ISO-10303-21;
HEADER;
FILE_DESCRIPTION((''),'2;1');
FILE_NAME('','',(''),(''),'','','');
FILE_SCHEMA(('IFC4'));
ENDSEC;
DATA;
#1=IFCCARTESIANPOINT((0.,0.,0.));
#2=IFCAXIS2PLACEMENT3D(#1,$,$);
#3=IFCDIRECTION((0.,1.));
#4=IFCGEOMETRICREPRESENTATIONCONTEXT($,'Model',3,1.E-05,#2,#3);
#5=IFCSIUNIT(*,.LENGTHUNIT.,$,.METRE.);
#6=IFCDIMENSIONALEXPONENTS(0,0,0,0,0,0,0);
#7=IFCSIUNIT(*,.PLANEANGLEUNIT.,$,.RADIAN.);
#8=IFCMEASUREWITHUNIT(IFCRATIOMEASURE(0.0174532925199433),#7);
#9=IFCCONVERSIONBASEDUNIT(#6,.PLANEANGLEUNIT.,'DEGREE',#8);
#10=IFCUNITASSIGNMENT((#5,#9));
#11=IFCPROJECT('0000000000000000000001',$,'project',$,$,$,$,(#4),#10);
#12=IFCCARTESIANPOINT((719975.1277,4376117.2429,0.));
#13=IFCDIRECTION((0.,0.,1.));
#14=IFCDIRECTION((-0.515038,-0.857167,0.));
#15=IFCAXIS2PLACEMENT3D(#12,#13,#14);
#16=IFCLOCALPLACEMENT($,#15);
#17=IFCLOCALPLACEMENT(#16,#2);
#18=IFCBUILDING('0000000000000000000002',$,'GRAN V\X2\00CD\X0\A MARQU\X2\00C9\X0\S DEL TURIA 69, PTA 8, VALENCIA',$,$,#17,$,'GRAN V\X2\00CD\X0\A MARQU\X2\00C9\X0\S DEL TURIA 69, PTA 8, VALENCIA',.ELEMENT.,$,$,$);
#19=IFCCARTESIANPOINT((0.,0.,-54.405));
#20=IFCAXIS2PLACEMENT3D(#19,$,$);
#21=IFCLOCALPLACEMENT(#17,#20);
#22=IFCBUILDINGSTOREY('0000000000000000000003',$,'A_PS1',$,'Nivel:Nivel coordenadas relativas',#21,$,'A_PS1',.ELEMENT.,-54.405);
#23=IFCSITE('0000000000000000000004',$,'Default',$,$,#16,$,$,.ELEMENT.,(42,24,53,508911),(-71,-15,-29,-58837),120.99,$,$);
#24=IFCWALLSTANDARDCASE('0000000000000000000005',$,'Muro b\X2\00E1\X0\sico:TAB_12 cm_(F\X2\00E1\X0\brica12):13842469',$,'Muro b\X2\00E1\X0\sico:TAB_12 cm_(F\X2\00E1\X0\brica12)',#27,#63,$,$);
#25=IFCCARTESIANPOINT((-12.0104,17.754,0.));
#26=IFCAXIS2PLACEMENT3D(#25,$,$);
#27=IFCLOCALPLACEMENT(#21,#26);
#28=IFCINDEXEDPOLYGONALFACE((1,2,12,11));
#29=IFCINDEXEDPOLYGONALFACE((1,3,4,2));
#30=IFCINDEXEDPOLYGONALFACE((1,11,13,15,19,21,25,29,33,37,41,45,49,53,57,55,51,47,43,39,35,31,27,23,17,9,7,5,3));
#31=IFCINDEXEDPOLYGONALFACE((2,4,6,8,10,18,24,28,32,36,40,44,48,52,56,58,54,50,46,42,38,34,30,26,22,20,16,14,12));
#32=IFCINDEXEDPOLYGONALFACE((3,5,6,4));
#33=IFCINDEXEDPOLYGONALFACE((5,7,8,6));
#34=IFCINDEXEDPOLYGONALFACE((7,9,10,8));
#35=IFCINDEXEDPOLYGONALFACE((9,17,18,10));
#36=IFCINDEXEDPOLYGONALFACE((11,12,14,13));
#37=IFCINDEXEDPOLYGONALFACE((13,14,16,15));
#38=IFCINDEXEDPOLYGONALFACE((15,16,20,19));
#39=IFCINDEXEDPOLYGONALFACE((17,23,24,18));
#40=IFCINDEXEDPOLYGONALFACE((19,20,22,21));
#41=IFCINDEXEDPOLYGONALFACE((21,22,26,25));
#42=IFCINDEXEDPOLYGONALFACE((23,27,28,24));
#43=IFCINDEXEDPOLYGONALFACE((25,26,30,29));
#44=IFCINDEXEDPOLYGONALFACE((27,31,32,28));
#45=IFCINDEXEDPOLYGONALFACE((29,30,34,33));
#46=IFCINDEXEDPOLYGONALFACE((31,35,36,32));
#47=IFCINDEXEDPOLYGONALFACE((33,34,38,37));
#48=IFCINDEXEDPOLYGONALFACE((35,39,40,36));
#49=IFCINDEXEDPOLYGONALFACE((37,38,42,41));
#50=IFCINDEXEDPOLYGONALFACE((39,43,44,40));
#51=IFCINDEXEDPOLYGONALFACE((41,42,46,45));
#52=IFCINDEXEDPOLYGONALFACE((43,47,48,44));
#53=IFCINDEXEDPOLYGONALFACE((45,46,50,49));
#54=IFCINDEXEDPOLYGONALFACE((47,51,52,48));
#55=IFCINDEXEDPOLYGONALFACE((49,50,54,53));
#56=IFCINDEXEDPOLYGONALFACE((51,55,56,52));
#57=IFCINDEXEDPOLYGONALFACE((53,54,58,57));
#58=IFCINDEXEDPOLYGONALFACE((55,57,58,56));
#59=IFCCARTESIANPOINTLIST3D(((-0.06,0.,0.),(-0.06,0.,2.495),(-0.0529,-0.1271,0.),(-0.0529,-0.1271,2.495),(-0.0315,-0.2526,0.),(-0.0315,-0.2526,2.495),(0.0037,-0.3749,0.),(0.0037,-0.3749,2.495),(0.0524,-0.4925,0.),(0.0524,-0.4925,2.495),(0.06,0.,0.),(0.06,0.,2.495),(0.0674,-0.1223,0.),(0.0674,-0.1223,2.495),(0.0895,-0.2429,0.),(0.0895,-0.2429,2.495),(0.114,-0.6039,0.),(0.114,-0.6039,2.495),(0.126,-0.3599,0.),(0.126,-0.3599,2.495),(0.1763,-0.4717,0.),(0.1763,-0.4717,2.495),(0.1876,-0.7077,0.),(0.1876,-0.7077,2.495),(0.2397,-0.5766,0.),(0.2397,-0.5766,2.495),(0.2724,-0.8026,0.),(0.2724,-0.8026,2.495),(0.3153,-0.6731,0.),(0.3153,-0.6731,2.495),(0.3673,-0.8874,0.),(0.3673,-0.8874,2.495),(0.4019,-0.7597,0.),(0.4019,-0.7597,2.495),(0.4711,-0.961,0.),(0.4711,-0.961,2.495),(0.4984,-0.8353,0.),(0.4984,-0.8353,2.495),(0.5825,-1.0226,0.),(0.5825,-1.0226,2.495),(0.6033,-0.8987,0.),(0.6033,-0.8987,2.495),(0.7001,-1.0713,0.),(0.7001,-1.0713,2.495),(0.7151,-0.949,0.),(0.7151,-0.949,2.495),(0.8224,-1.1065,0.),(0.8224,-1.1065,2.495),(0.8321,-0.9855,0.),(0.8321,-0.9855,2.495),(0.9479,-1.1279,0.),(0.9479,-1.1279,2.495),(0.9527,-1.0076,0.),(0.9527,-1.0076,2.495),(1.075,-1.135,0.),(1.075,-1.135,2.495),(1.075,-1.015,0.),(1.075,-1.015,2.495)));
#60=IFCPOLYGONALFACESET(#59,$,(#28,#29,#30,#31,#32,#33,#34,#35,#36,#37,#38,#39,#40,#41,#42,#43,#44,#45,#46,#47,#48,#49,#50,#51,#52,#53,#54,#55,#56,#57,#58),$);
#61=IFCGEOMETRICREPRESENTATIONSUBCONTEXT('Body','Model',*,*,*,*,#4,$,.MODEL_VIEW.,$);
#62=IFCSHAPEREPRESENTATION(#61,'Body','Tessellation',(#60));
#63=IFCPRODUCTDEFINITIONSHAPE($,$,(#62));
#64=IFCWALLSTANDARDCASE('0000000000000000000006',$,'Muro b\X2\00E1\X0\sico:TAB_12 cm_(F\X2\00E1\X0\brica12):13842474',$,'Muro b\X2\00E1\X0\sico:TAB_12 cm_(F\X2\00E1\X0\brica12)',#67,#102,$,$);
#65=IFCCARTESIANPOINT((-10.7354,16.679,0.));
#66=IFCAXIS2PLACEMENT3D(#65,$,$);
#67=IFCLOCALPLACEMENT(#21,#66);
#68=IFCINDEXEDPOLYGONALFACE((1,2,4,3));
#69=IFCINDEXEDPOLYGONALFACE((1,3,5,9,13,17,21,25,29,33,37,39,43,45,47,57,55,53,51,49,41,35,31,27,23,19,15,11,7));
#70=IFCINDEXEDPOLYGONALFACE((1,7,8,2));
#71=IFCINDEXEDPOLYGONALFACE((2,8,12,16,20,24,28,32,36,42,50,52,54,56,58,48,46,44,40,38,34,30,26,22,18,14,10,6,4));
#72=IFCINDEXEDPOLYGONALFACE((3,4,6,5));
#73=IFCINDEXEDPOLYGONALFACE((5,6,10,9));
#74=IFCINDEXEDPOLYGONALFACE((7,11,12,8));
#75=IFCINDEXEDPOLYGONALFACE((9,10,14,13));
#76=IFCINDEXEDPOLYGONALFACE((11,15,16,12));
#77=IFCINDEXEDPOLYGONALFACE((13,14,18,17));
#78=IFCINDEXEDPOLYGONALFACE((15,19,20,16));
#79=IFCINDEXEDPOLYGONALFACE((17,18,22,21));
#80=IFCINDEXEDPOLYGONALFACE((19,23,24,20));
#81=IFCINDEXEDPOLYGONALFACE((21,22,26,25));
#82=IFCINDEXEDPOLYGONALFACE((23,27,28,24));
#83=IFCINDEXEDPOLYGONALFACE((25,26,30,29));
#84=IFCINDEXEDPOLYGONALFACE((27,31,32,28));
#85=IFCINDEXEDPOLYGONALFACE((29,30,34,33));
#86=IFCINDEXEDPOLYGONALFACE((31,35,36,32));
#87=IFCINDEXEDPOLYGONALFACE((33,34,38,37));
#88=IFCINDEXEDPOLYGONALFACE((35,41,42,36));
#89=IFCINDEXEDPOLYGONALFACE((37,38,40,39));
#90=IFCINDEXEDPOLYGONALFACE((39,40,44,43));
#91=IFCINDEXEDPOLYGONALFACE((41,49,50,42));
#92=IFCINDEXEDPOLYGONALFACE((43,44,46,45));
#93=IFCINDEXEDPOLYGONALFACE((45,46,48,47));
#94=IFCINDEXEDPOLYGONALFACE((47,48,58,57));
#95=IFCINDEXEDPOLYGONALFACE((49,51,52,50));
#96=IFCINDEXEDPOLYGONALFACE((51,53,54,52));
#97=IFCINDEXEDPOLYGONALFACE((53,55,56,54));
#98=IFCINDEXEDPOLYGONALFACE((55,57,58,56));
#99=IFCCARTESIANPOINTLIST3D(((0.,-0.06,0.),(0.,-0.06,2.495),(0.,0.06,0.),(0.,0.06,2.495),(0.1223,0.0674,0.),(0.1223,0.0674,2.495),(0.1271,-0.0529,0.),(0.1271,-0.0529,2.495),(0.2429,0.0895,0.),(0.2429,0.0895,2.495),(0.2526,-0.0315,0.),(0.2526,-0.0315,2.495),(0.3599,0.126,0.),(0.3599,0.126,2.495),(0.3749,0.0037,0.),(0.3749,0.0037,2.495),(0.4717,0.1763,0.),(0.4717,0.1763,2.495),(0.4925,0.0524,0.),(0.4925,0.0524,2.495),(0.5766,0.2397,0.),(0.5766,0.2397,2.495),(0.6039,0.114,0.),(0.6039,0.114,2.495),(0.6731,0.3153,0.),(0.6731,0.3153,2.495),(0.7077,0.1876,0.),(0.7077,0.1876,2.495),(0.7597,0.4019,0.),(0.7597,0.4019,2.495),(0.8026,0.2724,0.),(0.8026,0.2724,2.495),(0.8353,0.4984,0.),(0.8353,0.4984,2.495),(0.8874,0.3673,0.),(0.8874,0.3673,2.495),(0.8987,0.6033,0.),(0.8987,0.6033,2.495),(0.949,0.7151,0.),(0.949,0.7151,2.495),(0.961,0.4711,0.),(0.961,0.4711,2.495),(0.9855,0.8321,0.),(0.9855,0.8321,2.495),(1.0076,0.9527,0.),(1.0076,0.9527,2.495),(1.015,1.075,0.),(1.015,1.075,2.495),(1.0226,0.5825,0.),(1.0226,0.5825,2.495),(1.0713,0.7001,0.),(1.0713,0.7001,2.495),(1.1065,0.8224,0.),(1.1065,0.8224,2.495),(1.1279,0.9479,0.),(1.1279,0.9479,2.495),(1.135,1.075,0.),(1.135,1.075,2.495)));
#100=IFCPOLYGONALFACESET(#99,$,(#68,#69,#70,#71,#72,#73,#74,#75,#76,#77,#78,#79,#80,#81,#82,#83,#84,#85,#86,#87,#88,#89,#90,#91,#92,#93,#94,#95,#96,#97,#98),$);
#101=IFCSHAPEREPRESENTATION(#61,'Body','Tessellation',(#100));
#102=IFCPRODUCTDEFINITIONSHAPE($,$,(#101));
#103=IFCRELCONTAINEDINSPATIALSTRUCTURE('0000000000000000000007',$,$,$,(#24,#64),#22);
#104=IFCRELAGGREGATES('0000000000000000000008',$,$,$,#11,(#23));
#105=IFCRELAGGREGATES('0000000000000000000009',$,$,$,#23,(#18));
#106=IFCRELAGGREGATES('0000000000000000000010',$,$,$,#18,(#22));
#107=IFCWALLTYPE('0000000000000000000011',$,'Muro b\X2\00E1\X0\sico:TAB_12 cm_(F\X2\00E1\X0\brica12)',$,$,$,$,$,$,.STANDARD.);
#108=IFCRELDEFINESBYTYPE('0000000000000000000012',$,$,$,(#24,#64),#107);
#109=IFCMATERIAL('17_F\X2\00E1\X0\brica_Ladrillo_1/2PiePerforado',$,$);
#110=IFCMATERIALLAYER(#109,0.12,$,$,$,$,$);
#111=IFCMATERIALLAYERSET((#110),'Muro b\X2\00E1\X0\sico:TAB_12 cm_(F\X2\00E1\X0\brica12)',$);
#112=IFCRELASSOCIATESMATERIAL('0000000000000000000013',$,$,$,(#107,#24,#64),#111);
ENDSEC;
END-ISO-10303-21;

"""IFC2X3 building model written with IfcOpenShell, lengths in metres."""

from ifc_helpers import new_model, entity, si_unit, converted_unit, direction, frame, frame_2d, origin, place, context, subcontext, project, spatial, polyline, circle_curve, parameter, trimmed, segment, composite_curve, outline, extrude, material, layer, layer_set, layer_usage, type_object, element, save


model = new_model("IFC2X3")

# Units and contexts
model_context = context("Model", 3, precision=1e-05, world=origin(), true_north=direction((0.0, 1.0)))
body_context = subcontext(model_context, "Body", "Model", "MODEL_VIEW")
ifc_project = project(units=[si_unit("LENGTHUNIT", "METRE"), converted_unit("PLANEANGLEUNIT", "DEGREE", entity("IfcRatioMeasure", 0.0174532925199433), si_unit("PLANEANGLEUNIT", "RADIAN"), dimensions=[0, 0, 0, 0, 0, 0, 0])], contexts=[model_context])

# Site, building, storey
site_placement = place(None, frame((719975.1277, 4376117.2429, 0.0), z_axis=(0.0, 0.0, 1.0), x_axis=(-0.515038, -0.857167, 0.0)))
site = spatial("IfcSite", under=ifc_project, at=site_placement, Name="Default", CompositionType="ELEMENT", RefLatitude=(42, 24, 53, 508911), RefLongitude=(-71, -15, -29, -58837), RefElevation=120.99)
building_placement = place(site_placement, origin())
building = spatial("IfcBuilding", under=site, at=building_placement, Name="GRAN VÍA MARQUÉS DEL TURIA 69, PTA 8, VALENCIA", LongName="GRAN VÍA MARQUÉS DEL TURIA 69, PTA 8, VALENCIA", CompositionType="ELEMENT")
storey_placement = place(building_placement, frame((0.0, 0.0, -54.405)))
storey = spatial("IfcBuildingStorey", under=building, at=storey_placement, Name="A_PS1", ObjectType="Nivel:Nivel coordenadas relativas", LongName="A_PS1", CompositionType="ELEMENT", Elevation=-54.405)

# Shared definitions
ifc_material_1 = material(Name="17_Fábrica_Ladrillo_1/2PiePerforado")
ifc_layer_1 = layer(ifc_material_1, 0.12)
ifc_layer_set_1 = layer_set([ifc_layer_1], Name="Muro básico:TAB_12 cm_(Fábrica12)")
wall_type_1 = type_object("IfcWallType", Name="Muro básico:TAB_12 cm_(Fábrica12)", PredefinedType="STANDARD", material=ifc_layer_set_1)

# Walls
ifc_layer_usage_1 = layer_usage(ifc_layer_set_1, "AXIS2", "NEGATIVE", 0.06)
wall_1_placement = place(storey_placement, frame((-12.0104, 17.754, 0.0)))
element("IfcWallStandardCase", 1, at=wall_1_placement, inside=storey, type_object=wall_type_1, material=ifc_layer_usage_1, Name="Muro básico:TAB_12 cm_(Fábrica12):13842469", ObjectType="Muro básico:TAB_12 cm_(Fábrica12)", context=body_context, shape_type="SweptSolid", body=[
    extrude(outline(composite_curve([segment(trimmed(circle_curve(frame_2d((1.075, 0.0), x_axis=(1.0, 0.0)), 1.015), [parameter(180.0)], [parameter(270.0)], True, "PARAMETER"), False, "CONTINUOUS"), segment(polyline([(0.06, 0.0), (-0.06, 0.0)]), True, "CONTINUOUS"), segment(trimmed(circle_curve(frame_2d((1.075, 0.0), x_axis=(1.0, 0.0)), 1.135), [parameter(180.0)], [parameter(270.0)], True, "PARAMETER"), True, "CONTINUOUS"), segment(polyline([(1.075, -1.135), (1.075, -1.015)]), True, "CONTINUOUS")], self_intersect=False)), origin(), (0.0, 0.0, 1.0), 2.495),
])
ifc_layer_usage_2 = layer_usage(ifc_layer_set_1, "AXIS2", "NEGATIVE", 0.06)
wall_2_placement = place(storey_placement, frame((-10.7354, 16.679, 0.0)))
element("IfcWallStandardCase", 2, at=wall_2_placement, inside=storey, type_object=wall_type_1, material=ifc_layer_usage_2, Name="Muro básico:TAB_12 cm_(Fábrica12):13842474", ObjectType="Muro básico:TAB_12 cm_(Fábrica12)", context=body_context, shape_type="SweptSolid", body=[
    extrude(outline(composite_curve([segment(trimmed(circle_curve(frame_2d((0.0, 1.075), x_axis=(1.0, 0.0)), 1.015), [parameter(270.0)], [parameter(360.0)], True, "PARAMETER"), False, "CONTINUOUS"), segment(polyline([(0.0, 0.06), (0.0, -0.06)]), True, "CONTINUOUS"), segment(trimmed(circle_curve(frame_2d((0.0, 1.075), x_axis=(1.0, 0.0)), 1.135), [parameter(270.0)], [parameter(360.0)], True, "PARAMETER"), True, "CONTINUOUS"), segment(polyline([(1.135, 1.075), (1.015, 1.075)]), True, "CONTINUOUS")], self_intersect=False)), origin(), (0.0, 0.0, 1.0), 2.495),
])

save(model, "model.ifc")
